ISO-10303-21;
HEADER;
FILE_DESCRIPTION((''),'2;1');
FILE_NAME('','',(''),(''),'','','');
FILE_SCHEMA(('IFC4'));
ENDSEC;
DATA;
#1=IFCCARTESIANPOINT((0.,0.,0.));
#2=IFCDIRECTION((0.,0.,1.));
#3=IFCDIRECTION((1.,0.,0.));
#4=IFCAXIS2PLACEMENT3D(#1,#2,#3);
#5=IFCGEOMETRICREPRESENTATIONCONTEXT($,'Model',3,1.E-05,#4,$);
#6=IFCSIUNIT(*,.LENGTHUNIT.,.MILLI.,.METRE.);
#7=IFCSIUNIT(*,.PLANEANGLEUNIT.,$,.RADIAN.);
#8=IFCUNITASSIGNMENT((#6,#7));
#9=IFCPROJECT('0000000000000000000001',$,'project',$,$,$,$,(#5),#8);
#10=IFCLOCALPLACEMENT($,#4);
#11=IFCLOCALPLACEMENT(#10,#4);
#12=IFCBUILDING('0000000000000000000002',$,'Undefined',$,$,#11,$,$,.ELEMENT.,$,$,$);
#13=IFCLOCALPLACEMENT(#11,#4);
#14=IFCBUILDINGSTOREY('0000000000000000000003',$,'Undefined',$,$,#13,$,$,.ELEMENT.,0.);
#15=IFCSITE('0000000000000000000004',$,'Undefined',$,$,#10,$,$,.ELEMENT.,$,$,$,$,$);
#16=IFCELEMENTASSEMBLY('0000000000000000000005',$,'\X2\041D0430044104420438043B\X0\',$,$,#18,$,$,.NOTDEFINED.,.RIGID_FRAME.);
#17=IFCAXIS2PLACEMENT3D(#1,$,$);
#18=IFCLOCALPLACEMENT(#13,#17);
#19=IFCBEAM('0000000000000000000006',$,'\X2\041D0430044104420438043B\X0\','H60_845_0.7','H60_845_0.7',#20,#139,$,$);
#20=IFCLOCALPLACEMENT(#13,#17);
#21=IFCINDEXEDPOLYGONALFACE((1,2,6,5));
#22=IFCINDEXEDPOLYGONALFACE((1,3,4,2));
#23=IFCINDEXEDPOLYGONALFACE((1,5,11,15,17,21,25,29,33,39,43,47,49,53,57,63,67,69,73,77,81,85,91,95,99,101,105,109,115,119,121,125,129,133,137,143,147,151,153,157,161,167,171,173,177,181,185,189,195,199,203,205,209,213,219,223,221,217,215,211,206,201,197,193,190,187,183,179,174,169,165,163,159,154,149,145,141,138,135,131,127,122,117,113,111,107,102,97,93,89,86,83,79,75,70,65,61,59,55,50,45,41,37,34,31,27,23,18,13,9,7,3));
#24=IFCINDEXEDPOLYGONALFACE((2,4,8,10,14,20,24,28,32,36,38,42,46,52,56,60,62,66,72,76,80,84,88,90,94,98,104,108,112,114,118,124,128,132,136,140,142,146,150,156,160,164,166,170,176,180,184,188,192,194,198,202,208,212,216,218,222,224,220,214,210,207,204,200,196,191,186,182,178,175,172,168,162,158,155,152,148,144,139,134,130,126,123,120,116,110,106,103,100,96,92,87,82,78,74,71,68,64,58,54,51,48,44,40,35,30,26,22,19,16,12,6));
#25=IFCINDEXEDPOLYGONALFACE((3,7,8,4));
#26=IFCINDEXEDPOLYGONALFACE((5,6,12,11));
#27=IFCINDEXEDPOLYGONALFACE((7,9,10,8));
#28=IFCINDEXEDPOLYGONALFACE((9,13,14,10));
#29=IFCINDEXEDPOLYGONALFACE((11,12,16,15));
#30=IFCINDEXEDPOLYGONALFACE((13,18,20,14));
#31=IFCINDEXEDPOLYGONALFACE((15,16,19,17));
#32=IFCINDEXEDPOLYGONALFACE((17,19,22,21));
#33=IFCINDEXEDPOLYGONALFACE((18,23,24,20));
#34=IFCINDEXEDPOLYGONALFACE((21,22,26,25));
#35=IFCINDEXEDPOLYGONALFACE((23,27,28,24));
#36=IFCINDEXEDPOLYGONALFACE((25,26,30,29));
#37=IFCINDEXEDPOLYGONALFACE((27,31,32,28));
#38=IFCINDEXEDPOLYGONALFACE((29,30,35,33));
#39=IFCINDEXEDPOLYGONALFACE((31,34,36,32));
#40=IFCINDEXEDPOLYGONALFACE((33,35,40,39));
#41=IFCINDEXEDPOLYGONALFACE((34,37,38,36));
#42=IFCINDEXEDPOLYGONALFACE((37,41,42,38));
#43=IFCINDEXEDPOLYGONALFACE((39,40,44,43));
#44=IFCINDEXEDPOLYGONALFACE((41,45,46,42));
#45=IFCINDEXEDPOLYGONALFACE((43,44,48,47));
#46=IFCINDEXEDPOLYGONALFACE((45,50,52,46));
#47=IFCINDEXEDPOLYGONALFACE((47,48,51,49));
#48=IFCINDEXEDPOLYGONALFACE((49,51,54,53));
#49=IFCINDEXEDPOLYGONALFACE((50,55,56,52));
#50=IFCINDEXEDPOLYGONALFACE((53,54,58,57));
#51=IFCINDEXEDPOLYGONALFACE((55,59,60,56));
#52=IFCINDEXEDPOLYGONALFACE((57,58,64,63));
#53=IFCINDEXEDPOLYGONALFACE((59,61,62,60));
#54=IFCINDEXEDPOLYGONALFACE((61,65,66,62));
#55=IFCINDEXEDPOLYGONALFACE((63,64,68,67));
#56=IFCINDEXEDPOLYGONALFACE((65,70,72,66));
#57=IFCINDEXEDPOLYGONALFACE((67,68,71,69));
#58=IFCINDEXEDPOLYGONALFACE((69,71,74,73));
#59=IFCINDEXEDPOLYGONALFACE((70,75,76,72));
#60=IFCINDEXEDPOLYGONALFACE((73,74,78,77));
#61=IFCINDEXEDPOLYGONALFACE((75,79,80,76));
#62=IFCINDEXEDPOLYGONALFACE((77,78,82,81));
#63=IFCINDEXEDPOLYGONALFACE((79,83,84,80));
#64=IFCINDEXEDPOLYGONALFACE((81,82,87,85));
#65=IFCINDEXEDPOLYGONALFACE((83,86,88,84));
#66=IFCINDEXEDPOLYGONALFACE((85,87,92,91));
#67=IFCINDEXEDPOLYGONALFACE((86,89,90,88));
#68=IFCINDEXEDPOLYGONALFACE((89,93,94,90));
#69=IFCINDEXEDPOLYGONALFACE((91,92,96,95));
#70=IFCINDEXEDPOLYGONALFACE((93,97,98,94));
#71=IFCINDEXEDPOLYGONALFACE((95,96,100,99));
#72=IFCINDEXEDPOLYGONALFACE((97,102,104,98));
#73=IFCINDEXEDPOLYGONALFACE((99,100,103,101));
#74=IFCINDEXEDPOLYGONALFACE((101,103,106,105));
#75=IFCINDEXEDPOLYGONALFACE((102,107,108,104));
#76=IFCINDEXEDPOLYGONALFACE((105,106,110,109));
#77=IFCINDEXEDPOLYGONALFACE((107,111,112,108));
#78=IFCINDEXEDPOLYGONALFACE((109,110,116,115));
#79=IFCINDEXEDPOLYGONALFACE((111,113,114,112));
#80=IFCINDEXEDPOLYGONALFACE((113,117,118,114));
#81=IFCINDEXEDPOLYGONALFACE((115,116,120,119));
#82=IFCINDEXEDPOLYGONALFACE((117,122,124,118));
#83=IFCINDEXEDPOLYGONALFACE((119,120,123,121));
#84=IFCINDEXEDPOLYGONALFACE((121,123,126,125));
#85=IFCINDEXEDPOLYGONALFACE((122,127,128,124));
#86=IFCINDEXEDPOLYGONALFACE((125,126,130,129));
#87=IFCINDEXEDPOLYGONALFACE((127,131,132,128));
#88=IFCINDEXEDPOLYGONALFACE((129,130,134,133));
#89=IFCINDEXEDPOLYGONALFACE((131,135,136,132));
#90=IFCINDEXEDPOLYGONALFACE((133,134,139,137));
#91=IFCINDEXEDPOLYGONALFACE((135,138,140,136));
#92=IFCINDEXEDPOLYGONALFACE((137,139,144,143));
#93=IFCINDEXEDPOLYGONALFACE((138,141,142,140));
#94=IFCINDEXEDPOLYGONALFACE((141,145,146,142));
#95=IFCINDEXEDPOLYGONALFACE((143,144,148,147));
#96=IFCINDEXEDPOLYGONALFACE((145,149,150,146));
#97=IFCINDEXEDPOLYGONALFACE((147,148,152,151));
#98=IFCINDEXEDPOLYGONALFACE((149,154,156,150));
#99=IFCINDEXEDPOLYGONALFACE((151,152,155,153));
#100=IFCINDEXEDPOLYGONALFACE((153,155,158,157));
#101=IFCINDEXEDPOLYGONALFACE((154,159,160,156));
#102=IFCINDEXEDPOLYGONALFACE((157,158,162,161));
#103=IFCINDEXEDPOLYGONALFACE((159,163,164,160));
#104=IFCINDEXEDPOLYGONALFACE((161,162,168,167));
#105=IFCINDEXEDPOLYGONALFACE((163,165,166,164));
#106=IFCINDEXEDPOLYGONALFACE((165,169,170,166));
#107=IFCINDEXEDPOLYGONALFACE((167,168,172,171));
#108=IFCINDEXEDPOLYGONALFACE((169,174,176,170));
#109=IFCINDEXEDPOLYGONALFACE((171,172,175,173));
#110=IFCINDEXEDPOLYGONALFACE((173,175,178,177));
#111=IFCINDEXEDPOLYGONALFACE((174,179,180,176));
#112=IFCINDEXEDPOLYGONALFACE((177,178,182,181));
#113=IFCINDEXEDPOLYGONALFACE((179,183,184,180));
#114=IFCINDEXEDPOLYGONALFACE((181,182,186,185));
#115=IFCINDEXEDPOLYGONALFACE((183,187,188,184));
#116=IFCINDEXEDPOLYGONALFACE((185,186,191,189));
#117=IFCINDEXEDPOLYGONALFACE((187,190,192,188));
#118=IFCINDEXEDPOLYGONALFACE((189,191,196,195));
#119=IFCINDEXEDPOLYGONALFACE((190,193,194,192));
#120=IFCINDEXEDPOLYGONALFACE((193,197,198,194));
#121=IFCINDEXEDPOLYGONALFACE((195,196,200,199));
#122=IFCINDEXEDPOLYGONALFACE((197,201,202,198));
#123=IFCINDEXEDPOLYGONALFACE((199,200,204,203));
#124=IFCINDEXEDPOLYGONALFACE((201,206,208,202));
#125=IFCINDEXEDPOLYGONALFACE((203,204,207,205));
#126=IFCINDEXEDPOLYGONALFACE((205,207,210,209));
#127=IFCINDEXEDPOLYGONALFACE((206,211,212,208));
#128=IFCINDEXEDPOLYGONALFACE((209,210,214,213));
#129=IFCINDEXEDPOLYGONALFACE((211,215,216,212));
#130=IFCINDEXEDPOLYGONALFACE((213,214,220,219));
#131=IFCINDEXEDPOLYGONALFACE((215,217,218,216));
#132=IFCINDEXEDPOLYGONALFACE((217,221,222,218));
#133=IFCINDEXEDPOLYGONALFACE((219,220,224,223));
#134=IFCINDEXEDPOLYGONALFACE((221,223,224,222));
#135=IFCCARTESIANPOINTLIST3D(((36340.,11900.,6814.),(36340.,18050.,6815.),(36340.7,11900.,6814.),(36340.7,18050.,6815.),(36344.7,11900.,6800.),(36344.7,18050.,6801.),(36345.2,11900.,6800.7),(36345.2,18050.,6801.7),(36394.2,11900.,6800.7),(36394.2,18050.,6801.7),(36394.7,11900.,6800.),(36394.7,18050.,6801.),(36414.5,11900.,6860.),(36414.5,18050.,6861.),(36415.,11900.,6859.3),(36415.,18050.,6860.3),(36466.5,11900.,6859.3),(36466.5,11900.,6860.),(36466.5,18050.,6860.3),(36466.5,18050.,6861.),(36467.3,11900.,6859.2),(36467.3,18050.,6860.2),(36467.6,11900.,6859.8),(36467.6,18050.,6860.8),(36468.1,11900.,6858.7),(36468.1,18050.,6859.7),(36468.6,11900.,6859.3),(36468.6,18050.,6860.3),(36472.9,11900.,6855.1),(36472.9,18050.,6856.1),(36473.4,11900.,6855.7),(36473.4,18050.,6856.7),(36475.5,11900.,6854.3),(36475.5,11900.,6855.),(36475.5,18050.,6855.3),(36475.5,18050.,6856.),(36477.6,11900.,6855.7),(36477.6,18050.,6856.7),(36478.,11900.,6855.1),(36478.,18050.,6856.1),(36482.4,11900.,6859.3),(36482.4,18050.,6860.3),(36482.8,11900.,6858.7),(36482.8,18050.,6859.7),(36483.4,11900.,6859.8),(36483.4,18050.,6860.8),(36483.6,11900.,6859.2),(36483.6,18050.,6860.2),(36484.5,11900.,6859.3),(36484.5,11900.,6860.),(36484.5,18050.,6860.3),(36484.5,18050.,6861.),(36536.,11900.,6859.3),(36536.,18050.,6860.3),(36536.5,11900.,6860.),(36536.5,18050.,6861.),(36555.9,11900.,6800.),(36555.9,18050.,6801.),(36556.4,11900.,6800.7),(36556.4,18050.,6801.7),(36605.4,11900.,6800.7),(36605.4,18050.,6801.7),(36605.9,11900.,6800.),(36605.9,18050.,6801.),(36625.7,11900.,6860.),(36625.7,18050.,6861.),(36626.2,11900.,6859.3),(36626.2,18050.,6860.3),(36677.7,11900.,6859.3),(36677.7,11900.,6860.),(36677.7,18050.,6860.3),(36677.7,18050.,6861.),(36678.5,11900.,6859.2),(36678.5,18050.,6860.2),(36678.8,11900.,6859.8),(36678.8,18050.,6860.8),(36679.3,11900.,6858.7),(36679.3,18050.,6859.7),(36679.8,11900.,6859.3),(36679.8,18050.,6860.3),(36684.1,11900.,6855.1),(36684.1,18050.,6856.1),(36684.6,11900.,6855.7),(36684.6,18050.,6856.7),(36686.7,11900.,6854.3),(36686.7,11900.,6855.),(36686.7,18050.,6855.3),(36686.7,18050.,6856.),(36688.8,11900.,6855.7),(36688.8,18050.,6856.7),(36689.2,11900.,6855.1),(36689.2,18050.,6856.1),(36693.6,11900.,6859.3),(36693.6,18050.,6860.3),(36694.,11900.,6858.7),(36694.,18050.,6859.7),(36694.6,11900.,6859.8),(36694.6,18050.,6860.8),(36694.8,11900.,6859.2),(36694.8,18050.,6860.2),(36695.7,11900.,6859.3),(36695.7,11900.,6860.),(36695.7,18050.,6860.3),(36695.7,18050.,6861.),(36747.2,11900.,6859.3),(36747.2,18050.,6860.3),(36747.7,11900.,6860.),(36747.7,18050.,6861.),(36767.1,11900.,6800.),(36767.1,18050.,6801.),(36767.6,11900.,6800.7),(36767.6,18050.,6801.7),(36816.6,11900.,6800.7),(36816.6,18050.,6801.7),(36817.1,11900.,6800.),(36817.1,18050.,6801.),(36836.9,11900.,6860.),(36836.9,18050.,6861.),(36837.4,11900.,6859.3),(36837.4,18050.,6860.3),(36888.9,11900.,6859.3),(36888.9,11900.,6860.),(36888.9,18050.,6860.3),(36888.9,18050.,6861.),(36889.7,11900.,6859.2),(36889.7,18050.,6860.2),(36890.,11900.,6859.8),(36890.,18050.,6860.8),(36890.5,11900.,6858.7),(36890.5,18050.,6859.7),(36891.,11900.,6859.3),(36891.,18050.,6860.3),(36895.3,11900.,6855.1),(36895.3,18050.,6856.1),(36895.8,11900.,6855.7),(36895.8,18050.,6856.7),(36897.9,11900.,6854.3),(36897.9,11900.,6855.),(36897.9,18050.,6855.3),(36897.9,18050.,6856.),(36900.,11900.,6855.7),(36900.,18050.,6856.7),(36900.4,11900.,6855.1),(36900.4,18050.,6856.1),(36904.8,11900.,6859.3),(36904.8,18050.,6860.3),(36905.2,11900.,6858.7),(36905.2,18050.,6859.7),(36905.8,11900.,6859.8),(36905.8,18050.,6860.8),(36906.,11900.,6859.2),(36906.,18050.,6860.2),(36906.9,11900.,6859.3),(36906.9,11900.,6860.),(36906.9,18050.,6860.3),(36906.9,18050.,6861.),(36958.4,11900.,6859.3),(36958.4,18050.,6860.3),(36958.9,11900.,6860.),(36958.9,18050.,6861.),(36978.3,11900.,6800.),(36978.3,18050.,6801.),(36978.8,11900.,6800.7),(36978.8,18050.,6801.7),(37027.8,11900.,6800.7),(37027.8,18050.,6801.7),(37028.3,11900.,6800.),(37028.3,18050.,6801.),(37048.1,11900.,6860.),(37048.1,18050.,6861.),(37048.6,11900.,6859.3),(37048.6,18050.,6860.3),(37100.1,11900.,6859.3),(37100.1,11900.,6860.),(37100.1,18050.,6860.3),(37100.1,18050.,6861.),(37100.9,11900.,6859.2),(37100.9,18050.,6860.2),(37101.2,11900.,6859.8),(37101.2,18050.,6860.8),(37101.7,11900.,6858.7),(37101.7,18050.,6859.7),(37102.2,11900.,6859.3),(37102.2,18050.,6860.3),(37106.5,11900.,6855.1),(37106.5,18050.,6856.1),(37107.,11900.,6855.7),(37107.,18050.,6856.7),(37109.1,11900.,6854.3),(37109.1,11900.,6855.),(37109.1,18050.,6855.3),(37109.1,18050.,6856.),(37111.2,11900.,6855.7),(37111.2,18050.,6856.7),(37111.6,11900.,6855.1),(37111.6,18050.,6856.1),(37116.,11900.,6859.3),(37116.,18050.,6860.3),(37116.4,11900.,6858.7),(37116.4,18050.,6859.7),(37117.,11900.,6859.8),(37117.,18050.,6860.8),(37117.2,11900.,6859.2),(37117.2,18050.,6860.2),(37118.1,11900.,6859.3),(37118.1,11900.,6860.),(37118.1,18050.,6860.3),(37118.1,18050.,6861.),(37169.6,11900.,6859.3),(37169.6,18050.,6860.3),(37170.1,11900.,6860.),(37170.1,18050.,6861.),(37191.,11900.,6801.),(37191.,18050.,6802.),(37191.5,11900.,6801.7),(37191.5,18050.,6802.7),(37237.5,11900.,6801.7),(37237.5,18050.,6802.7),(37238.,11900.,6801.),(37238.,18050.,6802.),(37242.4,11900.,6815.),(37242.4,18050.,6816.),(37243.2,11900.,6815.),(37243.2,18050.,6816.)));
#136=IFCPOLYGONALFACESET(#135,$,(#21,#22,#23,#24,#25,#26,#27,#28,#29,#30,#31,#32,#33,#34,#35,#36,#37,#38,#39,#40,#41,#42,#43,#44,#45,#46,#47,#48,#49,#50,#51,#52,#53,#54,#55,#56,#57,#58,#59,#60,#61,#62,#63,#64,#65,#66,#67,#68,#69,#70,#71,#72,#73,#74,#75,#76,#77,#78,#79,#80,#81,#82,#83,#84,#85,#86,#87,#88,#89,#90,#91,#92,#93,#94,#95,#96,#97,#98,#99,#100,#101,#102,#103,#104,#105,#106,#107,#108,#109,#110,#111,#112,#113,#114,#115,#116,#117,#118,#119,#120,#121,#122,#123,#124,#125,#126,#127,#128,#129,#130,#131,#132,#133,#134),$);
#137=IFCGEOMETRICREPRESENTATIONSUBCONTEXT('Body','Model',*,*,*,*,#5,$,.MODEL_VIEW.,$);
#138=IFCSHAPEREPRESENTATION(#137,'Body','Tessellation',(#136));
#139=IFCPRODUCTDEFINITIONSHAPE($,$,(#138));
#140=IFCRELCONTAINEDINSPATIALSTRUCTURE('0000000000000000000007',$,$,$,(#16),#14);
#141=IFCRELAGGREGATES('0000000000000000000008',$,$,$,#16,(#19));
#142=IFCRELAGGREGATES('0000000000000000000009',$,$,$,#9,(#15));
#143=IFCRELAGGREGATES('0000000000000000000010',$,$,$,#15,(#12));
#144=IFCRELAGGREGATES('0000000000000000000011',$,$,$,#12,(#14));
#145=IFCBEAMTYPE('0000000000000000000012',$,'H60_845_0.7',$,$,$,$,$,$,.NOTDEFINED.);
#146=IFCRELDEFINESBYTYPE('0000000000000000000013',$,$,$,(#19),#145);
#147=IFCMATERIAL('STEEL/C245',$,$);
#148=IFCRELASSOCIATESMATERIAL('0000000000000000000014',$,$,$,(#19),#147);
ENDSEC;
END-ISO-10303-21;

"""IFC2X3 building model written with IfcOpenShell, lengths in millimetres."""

from ifc_helpers import new_model, si_unit, frame, origin_with_axes, place, context, subcontext, project, spatial, polyline, outline, extrude, material, type_object, element, aggregate, save


model = new_model("IFC2X3")

# Units and contexts
model_context = context("Model", 3, precision=1e-05, world=origin_with_axes())
body_context = subcontext(model_context, "Body", "Model", "MODEL_VIEW")
ifc_project = project(units=[si_unit("LENGTHUNIT", "METRE", prefix="MILLI"), si_unit("PLANEANGLEUNIT", "RADIAN")], contexts=[model_context])

# Site, building, storey
site_placement = place(None, origin_with_axes())
site = spatial("IfcSite", under=ifc_project, at=site_placement, Name="Undefined", CompositionType="ELEMENT")
building_placement = place(site_placement, origin_with_axes())
building = spatial("IfcBuilding", under=site, at=building_placement, Name="Undefined", CompositionType="ELEMENT")
storey_placement = place(building_placement, origin_with_axes())
storey = spatial("IfcBuildingStorey", under=building, at=storey_placement, Name="Undefined", CompositionType="ELEMENT", Elevation=0.0)

# Element assembly, beam
ifc_material_1 = material(Name="STEEL/C245")
beam_type_1 = type_object("IfcBeamType", Name="H60_845_0.7", PredefinedType="NOTDEFINED")
assembly_1_placement = place(storey_placement, origin_with_axes())
assembly_1 = element("IfcElementAssembly", 1, at=assembly_1_placement, inside=storey, Name="Настил", AssemblyPlace="NOTDEFINED", PredefinedType="RIGID_FRAME")
beam_1_placement = place(assembly_1_placement, frame((36791.2, 18050.0, 6831.0), z_axis=(0.0, -0.000163, 1.0), x_axis=(0.0, -1.0, -0.000163)))
beam_1 = element("IfcBeam", 2, at=beam_1_placement, type_object=beam_type_1, material=ifc_material_1, Name="Настил", Description="H60_845_0.7", ObjectType="H60_845_0.7", context=body_context, shape_type="SweptSolid", body=[
    extrude(outline(polyline([(-399.8, -29.0), (-446.8, -29.0), (-452.0, -15.0), (-451.2, -15.0), (-446.3, -28.3), (-400.3, -28.3), (-378.9, 30.0), (-326.9, 30.0), (-325.7, 29.8), (-324.7, 29.3), (-320.0, 25.7), (-317.9, 25.0), (-315.8, 25.7), (-311.0, 29.3), (-310.0, 29.8), (-308.9, 30.0), (-256.9, 30.0), (-236.6, -29.3), (-187.6, -29.3), (-167.7, 30.0), (-115.7, 30.0), (-114.5, 29.8), (-113.5, 29.3), (-108.8, 25.7), (-106.7, 25.0), (-104.6, 25.7), (-99.7, 29.3), (-98.8, 29.8), (-97.7, 30.0), (-45.7, 30.0), (-25.4, -29.3), (23.6, -29.3), (43.5, 30.0), (95.5, 30.0), (96.7, 29.8), (97.7, 29.3), (102.4, 25.7), (104.5, 25.0), (106.6, 25.7), (111.4, 29.3), (112.4, 29.8), (113.5, 30.0), (165.5, 30.0), (185.8, -29.3), (234.8, -29.3), (254.7, 30.0), (306.7, 30.0), (307.9, 29.8), (308.9, 29.3), (313.6, 25.7), (315.7, 25.0), (317.8, 25.7), (322.6, 29.3), (323.6, 29.8), (324.7, 30.0), (376.7, 30.0), (397.0, -29.3), (446.0, -29.3), (450.5, -16.0), (451.2, -16.0), (446.5, -30.0), (396.5, -30.0), (376.2, 29.3), (324.7, 29.3), (323.9, 29.2), (323.1, 28.7), (318.3, 25.1), (315.7, 24.3), (313.2, 25.1), (308.4, 28.7), (307.6, 29.2), (306.7, 29.3), (255.2, 29.3), (235.3, -30.0), (185.3, -30.0), (165.0, 29.3), (113.5, 29.3), (112.7, 29.2), (111.9, 28.7), (107.1, 25.1), (104.5, 24.3), (102.0, 25.1), (97.2, 28.7), (96.4, 29.2), (95.5, 29.3), (44.0, 29.3), (24.1, -30.0), (-25.9, -30.0), (-46.2, 29.3), (-97.7, 29.3), (-98.5, 29.2), (-99.3, 28.7), (-104.1, 25.1), (-106.7, 24.3), (-109.2, 25.1), (-114.0, 28.7), (-114.8, 29.2), (-115.7, 29.3), (-167.2, 29.3), (-187.1, -30.0), (-237.1, -30.0), (-257.4, 29.3), (-308.9, 29.3), (-309.7, 29.2), (-310.5, 28.7), (-315.3, 25.1), (-317.9, 24.3), (-320.4, 25.1), (-325.2, 28.7), (-326.0, 29.2), (-326.9, 29.3), (-378.4, 29.3), (-399.8, -29.0)])), frame((6150.0, 0.0, 0.0), z_axis=(-1.0, 0.0, 0.0), x_axis=(0.0, -1.0, 0.0)), (0.0, 0.0, 1.0), 6150.0),
])
aggregate(assembly_1, [beam_1])

save(model, "model.ifc")
